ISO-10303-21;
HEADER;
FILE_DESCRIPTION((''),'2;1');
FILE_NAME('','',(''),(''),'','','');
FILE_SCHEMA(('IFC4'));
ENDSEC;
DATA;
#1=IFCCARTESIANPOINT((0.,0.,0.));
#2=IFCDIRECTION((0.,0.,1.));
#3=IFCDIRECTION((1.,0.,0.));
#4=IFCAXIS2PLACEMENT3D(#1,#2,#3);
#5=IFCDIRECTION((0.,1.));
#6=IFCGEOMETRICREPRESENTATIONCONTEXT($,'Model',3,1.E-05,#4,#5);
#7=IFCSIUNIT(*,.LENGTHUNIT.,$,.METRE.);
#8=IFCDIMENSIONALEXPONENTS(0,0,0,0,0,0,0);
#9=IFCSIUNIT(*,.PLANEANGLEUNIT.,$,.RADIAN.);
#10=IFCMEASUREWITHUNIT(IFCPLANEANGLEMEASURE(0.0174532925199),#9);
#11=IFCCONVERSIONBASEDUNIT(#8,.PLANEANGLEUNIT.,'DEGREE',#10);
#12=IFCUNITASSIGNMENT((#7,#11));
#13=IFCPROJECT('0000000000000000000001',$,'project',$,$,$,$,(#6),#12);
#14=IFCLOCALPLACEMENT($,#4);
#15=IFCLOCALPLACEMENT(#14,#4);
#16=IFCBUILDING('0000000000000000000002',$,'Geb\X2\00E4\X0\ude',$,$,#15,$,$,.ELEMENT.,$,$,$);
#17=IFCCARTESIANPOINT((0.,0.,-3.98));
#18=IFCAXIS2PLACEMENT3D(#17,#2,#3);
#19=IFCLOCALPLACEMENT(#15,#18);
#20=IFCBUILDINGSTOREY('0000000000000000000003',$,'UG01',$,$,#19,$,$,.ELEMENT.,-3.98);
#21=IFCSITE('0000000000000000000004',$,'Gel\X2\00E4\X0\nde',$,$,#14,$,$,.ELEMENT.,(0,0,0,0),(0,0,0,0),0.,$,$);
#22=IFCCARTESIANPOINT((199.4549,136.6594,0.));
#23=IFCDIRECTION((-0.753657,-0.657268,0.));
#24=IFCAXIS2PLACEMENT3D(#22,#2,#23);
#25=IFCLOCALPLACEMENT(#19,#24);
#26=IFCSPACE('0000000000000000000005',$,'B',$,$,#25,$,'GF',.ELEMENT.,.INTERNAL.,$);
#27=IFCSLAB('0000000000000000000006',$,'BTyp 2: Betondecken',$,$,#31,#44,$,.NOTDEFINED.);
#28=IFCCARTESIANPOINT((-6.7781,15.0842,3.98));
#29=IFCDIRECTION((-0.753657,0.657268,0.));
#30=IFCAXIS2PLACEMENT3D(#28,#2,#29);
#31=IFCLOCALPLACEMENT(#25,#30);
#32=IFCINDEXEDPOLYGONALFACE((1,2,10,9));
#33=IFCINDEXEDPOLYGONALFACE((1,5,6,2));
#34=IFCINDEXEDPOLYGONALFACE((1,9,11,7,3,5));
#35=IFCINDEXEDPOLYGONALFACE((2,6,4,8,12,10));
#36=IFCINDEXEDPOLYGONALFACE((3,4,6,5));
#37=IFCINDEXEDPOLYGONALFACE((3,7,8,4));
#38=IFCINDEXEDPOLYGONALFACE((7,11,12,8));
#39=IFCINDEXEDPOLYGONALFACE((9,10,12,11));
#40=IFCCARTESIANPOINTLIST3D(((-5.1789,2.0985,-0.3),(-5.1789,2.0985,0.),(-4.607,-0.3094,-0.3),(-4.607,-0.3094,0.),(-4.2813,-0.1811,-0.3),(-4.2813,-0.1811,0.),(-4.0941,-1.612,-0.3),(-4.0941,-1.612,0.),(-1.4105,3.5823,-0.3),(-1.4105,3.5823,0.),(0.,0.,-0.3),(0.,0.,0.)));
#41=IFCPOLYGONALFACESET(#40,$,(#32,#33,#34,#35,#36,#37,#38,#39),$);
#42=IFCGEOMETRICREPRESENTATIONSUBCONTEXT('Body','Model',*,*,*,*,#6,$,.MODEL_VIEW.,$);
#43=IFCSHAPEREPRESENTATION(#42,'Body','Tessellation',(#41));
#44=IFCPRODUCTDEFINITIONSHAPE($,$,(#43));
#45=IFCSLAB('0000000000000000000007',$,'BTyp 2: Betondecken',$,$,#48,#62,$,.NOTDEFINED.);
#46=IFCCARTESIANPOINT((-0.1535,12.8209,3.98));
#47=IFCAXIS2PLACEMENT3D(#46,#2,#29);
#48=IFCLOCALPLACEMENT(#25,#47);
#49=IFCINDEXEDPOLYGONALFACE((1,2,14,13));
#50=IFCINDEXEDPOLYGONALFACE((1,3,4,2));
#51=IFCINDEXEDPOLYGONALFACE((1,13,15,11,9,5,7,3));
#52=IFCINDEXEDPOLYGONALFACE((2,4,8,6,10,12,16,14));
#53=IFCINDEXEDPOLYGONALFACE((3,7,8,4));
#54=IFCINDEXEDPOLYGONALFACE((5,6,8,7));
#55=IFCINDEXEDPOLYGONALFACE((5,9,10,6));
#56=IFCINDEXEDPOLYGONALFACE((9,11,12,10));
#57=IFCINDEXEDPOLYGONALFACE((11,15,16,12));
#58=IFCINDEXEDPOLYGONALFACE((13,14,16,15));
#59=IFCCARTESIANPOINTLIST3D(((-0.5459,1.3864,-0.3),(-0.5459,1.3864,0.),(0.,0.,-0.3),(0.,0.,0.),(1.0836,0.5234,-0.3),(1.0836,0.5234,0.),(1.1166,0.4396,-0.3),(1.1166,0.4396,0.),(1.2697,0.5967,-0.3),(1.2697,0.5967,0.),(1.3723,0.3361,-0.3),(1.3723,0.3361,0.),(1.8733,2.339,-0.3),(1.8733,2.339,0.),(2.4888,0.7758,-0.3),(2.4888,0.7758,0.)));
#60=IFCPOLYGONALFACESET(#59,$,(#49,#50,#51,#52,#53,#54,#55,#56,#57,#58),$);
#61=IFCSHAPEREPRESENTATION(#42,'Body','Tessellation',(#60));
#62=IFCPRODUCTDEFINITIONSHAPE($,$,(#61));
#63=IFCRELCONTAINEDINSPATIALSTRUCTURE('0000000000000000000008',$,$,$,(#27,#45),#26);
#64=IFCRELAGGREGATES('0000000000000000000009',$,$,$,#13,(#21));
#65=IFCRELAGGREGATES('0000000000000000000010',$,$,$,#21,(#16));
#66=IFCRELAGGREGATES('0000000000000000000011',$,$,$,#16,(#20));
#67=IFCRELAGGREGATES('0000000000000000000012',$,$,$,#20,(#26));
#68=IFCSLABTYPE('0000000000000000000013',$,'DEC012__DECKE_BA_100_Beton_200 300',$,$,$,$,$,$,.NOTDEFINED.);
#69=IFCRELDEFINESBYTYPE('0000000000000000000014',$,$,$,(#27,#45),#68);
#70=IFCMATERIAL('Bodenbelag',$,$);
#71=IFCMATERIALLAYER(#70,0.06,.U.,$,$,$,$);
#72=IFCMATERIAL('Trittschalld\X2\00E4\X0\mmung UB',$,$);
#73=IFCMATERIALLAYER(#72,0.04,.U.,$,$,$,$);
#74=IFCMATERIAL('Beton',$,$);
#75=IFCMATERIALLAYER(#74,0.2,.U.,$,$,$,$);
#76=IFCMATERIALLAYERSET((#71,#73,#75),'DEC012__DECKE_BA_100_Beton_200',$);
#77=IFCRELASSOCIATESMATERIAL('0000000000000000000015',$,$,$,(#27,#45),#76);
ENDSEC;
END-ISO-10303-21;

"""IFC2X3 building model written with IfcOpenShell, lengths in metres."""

from ifc_helpers import new_model, entity, si_unit, converted_unit, direction, frame, origin_with_axes, place, context, subcontext, project, spatial, polyline, outline, extrude, material, layer, layer_set, layer_usage, type_object, element, save


model = new_model("IFC2X3")

# Units and contexts
model_context = context("Model", 3, precision=1e-05, world=origin_with_axes(), true_north=direction((0.0, 1.0)))
body_context = subcontext(model_context, "Body", "Model", "MODEL_VIEW")
ifc_project = project(units=[si_unit("LENGTHUNIT", "METRE"), converted_unit("PLANEANGLEUNIT", "DEGREE", entity("IfcPlaneAngleMeasure", 0.0174532925199), si_unit("PLANEANGLEUNIT", "RADIAN"), dimensions=[0, 0, 0, 0, 0, 0, 0])], contexts=[model_context])

# Site, building, storey, space
site_placement = place(None, origin_with_axes())
site = spatial("IfcSite", under=ifc_project, at=site_placement, Name="Gelände", CompositionType="ELEMENT", RefLatitude=(0, 0, 0, 0), RefLongitude=(0, 0, 0, 0), RefElevation=0.0)
building_placement = place(site_placement, origin_with_axes())
building = spatial("IfcBuilding", under=site, at=building_placement, Name="Gebäude", CompositionType="ELEMENT")
storey_placement = place(building_placement, frame((0.0, 0.0, -3.98), z_axis=(0.0, 0.0, 1.0), x_axis=(1.0, 0.0, 0.0)))
storey = spatial("IfcBuildingStorey", under=building, at=storey_placement, Name="UG01", CompositionType="ELEMENT", Elevation=-3.98)
space_1_placement = place(storey_placement, frame((199.4549, 136.6594, 0.0), z_axis=(0.0, 0.0, 1.0), x_axis=(-0.753657, -0.657268, 0.0)))
space_1 = spatial("IfcSpace", under=storey, at=space_1_placement, Name="B", LongName="GF", CompositionType="ELEMENT", InteriorOrExteriorSpace="INTERNAL")

# Slabs
ifc_material_1 = material(Name="Bodenbelag")
ifc_layer_1 = layer(ifc_material_1, 0.06, ventilated="UNKNOWN")
ifc_material_2 = material(Name="Trittschalldämmung UB")
ifc_layer_2 = layer(ifc_material_2, 0.04, ventilated="UNKNOWN")
ifc_material_3 = material(Name="Beton")
ifc_layer_3 = layer(ifc_material_3, 0.2, ventilated="UNKNOWN")
ifc_layer_set_1 = layer_set([ifc_layer_1, ifc_layer_2, ifc_layer_3], Name="DEC012__DECKE_BA_100_Beton_200")
ifc_layer_usage_1 = layer_usage(ifc_layer_set_1, "AXIS3", "NEGATIVE", 0.3)
slab_type_1 = type_object("IfcSlabType", Name="DEC012__DECKE_BA_100_Beton_200 300", PredefinedType="NOTDEFINED")
slab_1_placement = place(space_1_placement, frame((-6.7781, 15.0842, 3.98), z_axis=(0.0, 0.0, 1.0), x_axis=(-0.753657, 0.657268, 0.0)))
element("IfcSlab", 1, at=slab_1_placement, inside=space_1, type_object=slab_type_1, material=ifc_layer_usage_1, Name="BTyp 2: Betondecken", PredefinedType="NOTDEFINED", context=body_context, shape_type="SweptSolid", body=[
    extrude(outline(polyline([(0.0, 0.0), (-1.4105, 3.5823), (-5.1789, 2.0985), (-4.2813, -0.1811), (-4.607, -0.3094), (-4.0941, -1.612), (0.0, 0.0)])), frame((0.0, 0.0, -0.3), z_axis=(0.0, 0.0, 1.0), x_axis=(1.0, 0.0, 0.0)), (0.0, 0.0, 1.0), 0.3),
])
slab_2_placement = place(space_1_placement, frame((-0.1535, 12.8209, 3.98), z_axis=(0.0, 0.0, 1.0), x_axis=(-0.753657, 0.657268, 0.0)))
element("IfcSlab", 2, at=slab_2_placement, inside=space_1, type_object=slab_type_1, material=ifc_layer_usage_1, Name="BTyp 2: Betondecken", PredefinedType="NOTDEFINED", context=body_context, shape_type="SweptSolid", body=[
    extrude(outline(polyline([(0.0, 0.0), (1.1166, 0.4396), (1.0836, 0.5234), (1.2697, 0.5967), (1.3723, 0.3361), (2.4888, 0.7758), (1.8733, 2.339), (-0.5459, 1.3864), (0.0, 0.0)])), frame((0.0, 0.0, -0.3), z_axis=(0.0, 0.0, 1.0), x_axis=(1.0, 0.0, 0.0)), (0.0, 0.0, 1.0), 0.3),
])

save(model, "model.ifc")
